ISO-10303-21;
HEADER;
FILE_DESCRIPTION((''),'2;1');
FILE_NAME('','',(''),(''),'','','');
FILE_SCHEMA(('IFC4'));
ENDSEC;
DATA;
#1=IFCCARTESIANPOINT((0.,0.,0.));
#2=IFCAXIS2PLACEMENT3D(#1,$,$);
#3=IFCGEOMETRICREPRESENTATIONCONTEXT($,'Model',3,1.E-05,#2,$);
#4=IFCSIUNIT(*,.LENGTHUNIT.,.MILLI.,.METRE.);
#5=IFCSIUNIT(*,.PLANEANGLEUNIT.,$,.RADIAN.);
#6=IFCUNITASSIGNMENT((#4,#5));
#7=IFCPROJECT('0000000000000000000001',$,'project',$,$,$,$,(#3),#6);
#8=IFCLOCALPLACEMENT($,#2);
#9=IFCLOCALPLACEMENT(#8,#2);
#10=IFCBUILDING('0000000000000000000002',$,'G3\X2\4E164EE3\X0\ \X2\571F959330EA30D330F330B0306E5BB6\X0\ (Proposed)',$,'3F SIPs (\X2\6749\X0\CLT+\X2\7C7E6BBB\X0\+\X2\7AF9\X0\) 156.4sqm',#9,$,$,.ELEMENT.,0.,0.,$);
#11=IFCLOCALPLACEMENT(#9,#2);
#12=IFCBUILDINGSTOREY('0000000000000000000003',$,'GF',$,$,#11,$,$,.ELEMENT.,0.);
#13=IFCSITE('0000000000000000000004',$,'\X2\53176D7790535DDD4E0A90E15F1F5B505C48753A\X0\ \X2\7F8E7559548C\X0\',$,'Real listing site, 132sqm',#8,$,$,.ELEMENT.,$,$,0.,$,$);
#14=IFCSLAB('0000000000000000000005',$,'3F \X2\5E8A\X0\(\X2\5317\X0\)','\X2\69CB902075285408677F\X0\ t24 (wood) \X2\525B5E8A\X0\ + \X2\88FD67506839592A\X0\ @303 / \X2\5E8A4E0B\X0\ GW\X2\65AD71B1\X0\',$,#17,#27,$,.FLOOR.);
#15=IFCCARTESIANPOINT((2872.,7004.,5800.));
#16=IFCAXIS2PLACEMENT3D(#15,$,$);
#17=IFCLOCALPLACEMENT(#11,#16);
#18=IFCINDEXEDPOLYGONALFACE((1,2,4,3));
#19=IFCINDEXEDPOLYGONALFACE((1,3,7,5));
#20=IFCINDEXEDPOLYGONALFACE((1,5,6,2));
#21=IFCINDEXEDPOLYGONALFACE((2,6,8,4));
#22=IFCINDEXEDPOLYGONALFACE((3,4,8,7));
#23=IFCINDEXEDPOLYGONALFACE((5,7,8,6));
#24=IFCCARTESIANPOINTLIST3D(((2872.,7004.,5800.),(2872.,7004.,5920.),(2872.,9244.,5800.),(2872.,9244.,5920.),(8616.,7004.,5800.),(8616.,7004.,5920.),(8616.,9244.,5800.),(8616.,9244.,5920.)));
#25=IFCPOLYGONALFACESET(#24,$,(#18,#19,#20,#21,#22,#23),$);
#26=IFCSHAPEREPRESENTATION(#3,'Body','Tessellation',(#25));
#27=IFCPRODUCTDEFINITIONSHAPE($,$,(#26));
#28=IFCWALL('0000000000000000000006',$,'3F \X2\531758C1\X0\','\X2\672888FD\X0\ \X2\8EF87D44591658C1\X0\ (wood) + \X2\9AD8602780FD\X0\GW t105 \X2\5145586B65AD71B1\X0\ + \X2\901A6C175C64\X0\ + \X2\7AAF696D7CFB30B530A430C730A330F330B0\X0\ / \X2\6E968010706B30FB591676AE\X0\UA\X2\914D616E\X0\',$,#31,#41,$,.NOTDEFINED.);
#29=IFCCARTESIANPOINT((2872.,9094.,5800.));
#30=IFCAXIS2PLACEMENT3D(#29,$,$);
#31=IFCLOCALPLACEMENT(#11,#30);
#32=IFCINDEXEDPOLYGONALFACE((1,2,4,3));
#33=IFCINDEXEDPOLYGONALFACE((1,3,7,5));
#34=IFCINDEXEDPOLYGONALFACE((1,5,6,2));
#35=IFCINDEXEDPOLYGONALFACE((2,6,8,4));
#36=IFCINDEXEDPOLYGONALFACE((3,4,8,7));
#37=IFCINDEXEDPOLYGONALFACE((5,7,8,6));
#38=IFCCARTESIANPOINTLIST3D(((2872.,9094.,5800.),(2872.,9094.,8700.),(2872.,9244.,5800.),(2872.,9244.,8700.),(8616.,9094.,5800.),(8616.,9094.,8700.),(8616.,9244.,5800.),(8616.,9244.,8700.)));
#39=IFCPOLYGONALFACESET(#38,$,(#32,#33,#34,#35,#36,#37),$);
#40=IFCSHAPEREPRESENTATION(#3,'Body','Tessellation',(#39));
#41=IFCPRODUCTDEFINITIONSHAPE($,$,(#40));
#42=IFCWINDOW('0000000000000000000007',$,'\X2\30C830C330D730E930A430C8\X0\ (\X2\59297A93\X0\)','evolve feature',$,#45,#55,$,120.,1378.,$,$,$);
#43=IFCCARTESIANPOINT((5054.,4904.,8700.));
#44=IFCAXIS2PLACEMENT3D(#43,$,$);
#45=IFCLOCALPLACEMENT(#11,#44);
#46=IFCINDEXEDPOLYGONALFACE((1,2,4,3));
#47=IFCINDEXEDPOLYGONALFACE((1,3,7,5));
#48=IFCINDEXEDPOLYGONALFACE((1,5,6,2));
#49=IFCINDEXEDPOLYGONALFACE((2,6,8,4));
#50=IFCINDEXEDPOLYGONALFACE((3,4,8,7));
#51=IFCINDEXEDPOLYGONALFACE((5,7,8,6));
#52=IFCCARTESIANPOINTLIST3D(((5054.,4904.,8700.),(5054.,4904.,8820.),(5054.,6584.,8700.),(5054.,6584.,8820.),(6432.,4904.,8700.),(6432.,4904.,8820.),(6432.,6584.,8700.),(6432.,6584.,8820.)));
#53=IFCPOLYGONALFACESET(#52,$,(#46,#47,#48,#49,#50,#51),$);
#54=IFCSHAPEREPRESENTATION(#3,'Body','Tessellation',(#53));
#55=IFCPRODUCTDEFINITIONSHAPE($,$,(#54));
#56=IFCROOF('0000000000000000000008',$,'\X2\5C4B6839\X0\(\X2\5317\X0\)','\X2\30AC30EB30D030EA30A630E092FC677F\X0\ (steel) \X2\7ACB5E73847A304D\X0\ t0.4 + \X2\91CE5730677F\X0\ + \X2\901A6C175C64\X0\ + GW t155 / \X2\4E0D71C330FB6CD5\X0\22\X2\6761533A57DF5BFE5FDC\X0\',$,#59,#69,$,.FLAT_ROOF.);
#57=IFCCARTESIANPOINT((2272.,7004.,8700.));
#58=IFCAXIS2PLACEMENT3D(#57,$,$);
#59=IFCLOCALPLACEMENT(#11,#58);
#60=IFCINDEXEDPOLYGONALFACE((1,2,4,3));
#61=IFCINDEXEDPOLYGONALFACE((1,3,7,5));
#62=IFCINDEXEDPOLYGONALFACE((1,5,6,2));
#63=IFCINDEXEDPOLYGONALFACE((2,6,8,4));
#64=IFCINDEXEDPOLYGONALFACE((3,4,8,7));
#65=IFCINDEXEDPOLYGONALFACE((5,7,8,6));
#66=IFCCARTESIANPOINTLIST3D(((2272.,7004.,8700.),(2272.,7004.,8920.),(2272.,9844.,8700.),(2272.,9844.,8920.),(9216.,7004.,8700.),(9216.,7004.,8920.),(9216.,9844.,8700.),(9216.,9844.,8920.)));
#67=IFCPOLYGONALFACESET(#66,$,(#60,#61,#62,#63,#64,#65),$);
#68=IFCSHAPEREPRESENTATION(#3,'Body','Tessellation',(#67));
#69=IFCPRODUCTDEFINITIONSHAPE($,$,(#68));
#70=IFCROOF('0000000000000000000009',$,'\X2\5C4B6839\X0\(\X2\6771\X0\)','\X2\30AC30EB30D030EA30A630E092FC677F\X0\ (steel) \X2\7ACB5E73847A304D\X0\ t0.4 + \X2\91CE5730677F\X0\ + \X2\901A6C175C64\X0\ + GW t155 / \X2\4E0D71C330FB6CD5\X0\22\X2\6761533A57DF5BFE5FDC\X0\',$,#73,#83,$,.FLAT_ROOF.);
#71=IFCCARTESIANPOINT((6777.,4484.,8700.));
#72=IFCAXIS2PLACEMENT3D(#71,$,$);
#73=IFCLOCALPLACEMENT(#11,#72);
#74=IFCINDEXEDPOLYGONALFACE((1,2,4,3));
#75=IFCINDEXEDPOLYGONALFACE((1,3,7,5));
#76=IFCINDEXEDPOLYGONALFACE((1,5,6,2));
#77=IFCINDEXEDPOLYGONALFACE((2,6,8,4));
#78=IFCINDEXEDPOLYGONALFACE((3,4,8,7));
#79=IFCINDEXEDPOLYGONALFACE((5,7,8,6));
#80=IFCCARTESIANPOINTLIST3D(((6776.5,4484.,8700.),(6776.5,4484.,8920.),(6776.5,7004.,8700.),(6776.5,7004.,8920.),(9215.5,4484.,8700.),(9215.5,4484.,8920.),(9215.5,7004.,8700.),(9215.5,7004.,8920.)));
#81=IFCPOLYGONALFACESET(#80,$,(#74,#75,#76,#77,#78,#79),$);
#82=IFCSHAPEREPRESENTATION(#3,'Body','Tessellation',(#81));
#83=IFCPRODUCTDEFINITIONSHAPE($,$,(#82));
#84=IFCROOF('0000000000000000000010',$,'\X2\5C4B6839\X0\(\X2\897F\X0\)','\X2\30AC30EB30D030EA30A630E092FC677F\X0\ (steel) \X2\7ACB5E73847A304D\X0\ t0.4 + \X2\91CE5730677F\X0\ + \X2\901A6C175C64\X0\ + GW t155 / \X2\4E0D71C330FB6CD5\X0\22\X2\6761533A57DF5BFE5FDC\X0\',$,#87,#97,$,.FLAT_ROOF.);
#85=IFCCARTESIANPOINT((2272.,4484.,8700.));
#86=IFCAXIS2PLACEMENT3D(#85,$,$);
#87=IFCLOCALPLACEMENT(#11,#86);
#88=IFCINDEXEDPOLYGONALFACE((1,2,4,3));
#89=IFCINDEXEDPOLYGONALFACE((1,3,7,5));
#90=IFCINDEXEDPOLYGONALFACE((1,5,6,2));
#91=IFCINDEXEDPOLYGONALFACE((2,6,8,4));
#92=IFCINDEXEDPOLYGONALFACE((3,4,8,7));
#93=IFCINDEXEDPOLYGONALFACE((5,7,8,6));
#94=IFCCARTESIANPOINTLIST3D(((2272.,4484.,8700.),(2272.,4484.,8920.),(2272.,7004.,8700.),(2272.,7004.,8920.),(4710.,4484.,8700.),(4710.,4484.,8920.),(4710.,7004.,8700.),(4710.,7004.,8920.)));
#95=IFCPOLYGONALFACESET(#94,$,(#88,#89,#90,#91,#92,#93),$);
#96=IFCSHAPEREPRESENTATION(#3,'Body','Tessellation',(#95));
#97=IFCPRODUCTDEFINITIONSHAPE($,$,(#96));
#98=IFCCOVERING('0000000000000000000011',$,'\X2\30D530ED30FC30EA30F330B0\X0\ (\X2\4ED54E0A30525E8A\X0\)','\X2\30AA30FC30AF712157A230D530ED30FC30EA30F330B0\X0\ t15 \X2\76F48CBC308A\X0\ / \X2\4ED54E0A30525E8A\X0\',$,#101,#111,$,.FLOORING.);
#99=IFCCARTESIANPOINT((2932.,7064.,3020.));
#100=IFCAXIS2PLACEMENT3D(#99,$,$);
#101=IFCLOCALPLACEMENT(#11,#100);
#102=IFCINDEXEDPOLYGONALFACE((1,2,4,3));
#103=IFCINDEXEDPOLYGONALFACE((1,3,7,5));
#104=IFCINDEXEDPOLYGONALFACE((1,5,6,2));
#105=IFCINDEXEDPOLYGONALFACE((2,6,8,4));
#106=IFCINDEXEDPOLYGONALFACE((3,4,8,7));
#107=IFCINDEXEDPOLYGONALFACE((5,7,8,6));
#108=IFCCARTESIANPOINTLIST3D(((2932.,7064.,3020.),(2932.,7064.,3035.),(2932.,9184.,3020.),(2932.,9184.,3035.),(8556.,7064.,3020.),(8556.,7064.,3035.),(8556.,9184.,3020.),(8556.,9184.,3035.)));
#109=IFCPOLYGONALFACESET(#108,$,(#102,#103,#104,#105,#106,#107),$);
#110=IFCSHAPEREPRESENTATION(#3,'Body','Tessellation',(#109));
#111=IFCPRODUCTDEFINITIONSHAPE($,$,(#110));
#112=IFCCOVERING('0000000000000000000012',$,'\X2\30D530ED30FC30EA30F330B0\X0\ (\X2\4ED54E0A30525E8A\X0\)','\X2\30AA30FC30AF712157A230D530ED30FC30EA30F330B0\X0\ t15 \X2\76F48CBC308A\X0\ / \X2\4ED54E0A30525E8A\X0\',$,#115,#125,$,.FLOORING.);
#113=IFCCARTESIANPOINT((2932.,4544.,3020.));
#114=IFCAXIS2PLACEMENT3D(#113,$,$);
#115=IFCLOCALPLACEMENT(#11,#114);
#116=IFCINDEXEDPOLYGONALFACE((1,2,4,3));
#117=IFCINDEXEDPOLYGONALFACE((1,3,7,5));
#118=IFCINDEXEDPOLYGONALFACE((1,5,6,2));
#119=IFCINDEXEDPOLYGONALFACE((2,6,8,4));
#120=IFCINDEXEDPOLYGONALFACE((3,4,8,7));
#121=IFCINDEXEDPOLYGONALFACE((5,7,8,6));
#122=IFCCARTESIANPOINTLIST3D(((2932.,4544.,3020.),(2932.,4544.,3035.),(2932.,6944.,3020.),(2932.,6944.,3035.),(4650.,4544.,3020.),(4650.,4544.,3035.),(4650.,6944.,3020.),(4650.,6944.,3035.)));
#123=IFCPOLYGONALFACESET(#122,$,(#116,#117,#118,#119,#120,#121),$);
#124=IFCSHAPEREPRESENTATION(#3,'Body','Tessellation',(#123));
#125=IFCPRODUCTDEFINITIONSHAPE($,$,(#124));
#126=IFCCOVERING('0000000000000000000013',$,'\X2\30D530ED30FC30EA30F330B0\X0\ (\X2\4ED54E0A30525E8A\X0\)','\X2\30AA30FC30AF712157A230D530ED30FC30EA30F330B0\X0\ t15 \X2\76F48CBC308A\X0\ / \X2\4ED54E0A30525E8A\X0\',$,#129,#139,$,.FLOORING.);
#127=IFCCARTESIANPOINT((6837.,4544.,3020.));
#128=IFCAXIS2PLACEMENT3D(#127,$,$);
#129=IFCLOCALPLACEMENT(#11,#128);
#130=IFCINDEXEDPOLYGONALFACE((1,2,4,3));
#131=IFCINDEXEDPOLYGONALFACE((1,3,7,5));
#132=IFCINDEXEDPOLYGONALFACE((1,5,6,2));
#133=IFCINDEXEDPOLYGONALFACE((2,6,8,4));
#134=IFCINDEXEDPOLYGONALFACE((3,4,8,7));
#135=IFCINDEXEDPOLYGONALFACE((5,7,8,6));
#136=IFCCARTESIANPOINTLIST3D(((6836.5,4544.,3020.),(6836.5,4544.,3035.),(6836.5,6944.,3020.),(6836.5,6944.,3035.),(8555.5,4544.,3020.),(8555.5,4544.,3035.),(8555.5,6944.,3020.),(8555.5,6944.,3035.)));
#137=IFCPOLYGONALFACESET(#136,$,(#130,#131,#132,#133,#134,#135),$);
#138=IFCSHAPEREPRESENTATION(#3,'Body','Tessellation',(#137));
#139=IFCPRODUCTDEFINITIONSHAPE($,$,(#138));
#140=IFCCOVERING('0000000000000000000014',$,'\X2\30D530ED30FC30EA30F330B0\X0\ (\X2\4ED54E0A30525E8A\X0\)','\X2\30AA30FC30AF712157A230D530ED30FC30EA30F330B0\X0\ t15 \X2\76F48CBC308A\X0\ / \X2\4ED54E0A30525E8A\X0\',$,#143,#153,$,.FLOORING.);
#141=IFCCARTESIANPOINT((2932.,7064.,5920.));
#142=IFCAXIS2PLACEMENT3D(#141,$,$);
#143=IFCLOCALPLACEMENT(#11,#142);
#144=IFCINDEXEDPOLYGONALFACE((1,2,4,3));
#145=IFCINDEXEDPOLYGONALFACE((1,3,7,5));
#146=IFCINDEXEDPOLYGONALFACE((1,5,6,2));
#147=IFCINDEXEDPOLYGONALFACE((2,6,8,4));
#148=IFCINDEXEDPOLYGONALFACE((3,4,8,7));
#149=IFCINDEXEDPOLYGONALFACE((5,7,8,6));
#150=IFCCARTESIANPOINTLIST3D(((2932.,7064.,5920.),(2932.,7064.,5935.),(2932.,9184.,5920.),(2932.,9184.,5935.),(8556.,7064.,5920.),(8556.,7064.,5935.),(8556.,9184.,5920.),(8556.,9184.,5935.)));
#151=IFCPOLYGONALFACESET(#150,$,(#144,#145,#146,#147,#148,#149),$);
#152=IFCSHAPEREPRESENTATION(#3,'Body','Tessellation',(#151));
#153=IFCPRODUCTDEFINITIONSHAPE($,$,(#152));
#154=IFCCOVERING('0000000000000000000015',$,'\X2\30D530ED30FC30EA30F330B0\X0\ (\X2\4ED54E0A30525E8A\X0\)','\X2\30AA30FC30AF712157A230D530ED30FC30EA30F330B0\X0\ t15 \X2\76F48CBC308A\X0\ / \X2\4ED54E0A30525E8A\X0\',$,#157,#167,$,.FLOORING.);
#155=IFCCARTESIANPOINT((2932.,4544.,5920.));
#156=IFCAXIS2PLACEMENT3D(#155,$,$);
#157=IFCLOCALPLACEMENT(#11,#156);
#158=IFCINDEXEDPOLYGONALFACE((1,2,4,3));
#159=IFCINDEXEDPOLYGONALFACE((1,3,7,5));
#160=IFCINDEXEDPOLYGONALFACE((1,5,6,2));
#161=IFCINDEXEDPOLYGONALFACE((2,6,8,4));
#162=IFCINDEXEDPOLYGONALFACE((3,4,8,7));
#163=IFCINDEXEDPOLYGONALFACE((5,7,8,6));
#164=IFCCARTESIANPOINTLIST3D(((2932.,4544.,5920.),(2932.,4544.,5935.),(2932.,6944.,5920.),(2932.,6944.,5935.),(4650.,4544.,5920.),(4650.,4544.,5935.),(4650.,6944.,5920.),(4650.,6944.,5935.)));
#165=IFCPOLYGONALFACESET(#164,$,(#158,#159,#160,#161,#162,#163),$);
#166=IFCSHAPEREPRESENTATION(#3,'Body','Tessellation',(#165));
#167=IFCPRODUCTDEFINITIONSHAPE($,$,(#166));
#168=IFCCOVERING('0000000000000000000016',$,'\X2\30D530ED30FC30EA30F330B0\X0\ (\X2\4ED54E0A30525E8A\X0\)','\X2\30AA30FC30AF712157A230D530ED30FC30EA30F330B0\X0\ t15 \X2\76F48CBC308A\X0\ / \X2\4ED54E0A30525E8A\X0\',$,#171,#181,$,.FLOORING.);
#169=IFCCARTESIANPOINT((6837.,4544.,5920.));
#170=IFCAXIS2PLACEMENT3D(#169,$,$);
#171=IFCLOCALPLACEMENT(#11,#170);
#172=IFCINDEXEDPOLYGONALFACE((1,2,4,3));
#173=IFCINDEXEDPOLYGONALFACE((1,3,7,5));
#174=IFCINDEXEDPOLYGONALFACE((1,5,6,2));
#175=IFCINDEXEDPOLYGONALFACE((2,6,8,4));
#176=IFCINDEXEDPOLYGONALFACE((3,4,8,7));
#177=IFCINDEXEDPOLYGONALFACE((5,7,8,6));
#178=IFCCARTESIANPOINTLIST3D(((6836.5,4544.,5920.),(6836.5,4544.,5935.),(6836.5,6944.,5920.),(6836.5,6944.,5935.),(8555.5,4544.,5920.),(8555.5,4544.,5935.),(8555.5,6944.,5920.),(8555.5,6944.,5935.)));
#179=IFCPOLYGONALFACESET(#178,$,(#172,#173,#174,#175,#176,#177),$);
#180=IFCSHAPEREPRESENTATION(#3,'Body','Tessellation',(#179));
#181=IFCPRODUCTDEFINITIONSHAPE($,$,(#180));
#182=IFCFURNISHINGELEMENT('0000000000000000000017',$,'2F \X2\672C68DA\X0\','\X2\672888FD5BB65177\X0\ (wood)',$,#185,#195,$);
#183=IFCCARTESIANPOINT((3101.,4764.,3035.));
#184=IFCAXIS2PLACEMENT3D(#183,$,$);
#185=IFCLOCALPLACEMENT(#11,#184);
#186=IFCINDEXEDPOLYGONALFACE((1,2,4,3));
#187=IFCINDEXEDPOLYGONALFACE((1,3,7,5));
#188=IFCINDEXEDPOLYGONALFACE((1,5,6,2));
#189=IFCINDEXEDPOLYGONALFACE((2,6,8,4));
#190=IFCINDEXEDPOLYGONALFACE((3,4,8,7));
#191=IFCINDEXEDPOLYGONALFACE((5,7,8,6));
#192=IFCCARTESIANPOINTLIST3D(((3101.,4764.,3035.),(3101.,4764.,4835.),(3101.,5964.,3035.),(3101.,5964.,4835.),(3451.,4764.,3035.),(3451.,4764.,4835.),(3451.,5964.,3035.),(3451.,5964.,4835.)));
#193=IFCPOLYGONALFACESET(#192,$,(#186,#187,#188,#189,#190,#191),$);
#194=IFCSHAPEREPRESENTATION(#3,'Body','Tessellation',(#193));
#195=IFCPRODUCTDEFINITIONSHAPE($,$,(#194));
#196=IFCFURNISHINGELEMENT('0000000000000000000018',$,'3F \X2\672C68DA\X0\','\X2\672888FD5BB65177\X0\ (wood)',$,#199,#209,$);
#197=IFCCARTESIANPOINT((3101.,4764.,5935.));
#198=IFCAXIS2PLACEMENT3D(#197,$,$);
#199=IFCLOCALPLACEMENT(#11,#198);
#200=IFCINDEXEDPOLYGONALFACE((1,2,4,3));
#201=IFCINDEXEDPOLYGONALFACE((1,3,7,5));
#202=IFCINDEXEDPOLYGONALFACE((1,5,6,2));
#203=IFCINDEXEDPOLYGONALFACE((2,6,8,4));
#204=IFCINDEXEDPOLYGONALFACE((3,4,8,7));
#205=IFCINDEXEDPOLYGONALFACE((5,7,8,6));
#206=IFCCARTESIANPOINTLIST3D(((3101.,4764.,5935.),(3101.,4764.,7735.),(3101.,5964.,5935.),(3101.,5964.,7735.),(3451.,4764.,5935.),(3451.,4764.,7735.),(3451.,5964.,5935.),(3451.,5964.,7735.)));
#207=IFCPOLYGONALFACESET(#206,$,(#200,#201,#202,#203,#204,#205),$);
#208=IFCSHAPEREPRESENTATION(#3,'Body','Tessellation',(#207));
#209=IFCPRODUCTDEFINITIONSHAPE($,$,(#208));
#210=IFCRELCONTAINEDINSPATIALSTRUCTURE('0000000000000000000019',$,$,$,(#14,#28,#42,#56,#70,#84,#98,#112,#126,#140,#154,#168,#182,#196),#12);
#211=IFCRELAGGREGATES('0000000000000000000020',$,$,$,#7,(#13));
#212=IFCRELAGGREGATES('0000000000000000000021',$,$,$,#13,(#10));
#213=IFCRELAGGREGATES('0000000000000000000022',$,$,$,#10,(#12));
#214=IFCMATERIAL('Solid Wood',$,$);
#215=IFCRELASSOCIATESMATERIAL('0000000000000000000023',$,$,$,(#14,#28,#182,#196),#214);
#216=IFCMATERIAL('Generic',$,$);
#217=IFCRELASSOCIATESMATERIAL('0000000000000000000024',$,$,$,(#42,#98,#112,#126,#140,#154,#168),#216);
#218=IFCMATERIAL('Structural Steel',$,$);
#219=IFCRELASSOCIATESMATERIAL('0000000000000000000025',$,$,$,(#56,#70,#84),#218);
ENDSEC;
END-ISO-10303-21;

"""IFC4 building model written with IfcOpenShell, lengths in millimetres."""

from ifc_helpers import new_model, si_unit, frame, frame_2d, origin, place, context, project, spatial, rectangle, extrude, material, element, save


model = new_model("IFC4")

# Units and contexts
model_context = context("Model", 3, precision=1e-05, world=origin())
ifc_project = project(units=[si_unit("LENGTHUNIT", "METRE", prefix="MILLI"), si_unit("PLANEANGLEUNIT", "RADIAN")], contexts=[model_context])

# Site, building, storey
site_placement = place(None, origin())
site = spatial("IfcSite", under=ifc_project, at=site_placement, Name="北海道川上郡弟子屈町 美留和", ObjectType="Real listing site, 132sqm", CompositionType="ELEMENT", RefElevation=0.0)
building_placement = place(site_placement, origin())
building = spatial("IfcBuilding", under=site, at=building_placement, Name="G3世代 土間リビングの家 (Proposed)", ObjectType="3F SIPs (杉CLT+籾殻+竹) 156.4sqm", CompositionType="ELEMENT", ElevationOfRefHeight=0.0, ElevationOfTerrain=0.0)
storey_placement = place(building_placement, origin())
storey = spatial("IfcBuildingStorey", under=building, at=storey_placement, Name="GF", CompositionType="ELEMENT", Elevation=0.0)

# Slab
ifc_material_1 = material(Name="Solid Wood")
slab_placement = place(storey_placement, frame((2872.0, 7004.0, 5800.0)))
element("IfcSlab", 1, at=slab_placement, inside=storey, material=ifc_material_1, Name="3F 床(北)", Description="構造用合板 t24 (wood) 剛床 + 製材根太 @303 / 床下 GW断熱", PredefinedType="FLOOR", context=model_context, shape_type="SweptSolid", body=[
    extrude(rectangle(XDim=5744.0, YDim=2240.0, at=frame_2d((2872.0, 1120.0))), frame((2872.0, 7004.0, 5800.0)), (0.0, 0.0, 1.0), 120.0),
])

# Wall
wall_1_placement = place(storey_placement, frame((2872.0, 9094.0, 5800.0)))
element("IfcWall", 2, at=wall_1_placement, inside=storey, material=ifc_material_1, Name="3F 北壁", Description="木製 軸組外壁 (wood) + 高性能GW t105 充填断熱 + 通気層 + 窯業系サイディング / 準耐火・外皮UA配慮", PredefinedType="NOTDEFINED", context=model_context, shape_type="SweptSolid", body=[
    extrude(rectangle(XDim=5744.0, YDim=150.0, at=frame_2d((2872.0, 75.0))), frame((2872.0, 9094.0, 5800.0)), (0.0, 0.0, 1.0), 2900.0),
])

# Window
ifc_material_2 = material(Name="Generic")
window_1_placement = place(storey_placement, frame((5054.0, 4904.0, 8700.0)))
element("IfcWindow", 3, at=window_1_placement, inside=storey, material=ifc_material_2, Name="トップライト (天窓)", Description="evolve feature", OverallHeight=120.0, OverallWidth=1378.0, context=model_context, shape_type="SweptSolid", body=[
    extrude(rectangle(XDim=1378.0, YDim=1680.0, at=frame_2d((689.0, 840.0))), frame((5054.0, 4904.0, 8700.0)), (0.0, 0.0, 1.0), 120.0),
])

# Roofs
ifc_material_3 = material(Name="Structural Steel")
roof_1_placement = place(storey_placement, frame((2272.0, 7004.0, 8700.0)))
element("IfcRoof", 4, at=roof_1_placement, inside=storey, material=ifc_material_3, Name="屋根(北)", Description="ガルバリウム鋼板 (steel) 立平葺き t0.4 + 野地板 + 通気層 + GW t155 / 不燃・法22条区域対応", PredefinedType="FLAT_ROOF", context=model_context, shape_type="SweptSolid", body=[
    extrude(rectangle(XDim=6944.0, YDim=2840.0, at=frame_2d((3472.0, 1420.0))), frame((2272.0, 7004.0, 8700.0)), (0.0, 0.0, 1.0), 220.0),
])
roof_2_placement = place(storey_placement, frame((6777.0, 4484.0, 8700.0)))
element("IfcRoof", 5, at=roof_2_placement, inside=storey, material=ifc_material_3, Name="屋根(東)", Description="ガルバリウム鋼板 (steel) 立平葺き t0.4 + 野地板 + 通気層 + GW t155 / 不燃・法22条区域対応", PredefinedType="FLAT_ROOF", context=model_context, shape_type="SweptSolid", body=[
    extrude(rectangle(XDim=2439.0, YDim=2520.0, at=frame_2d((1219.0, 1260.0))), frame((6777.0, 4484.0, 8700.0)), (0.0, 0.0, 1.0), 220.0),
])
roof_3_placement = place(storey_placement, frame((2272.0, 4484.0, 8700.0)))
element("IfcRoof", 6, at=roof_3_placement, inside=storey, material=ifc_material_3, Name="屋根(西)", Description="ガルバリウム鋼板 (steel) 立平葺き t0.4 + 野地板 + 通気層 + GW t155 / 不燃・法22条区域対応", PredefinedType="FLAT_ROOF", context=model_context, shape_type="SweptSolid", body=[
    extrude(rectangle(XDim=2438.0, YDim=2520.0, at=frame_2d((1219.0, 1260.0))), frame((2272.0, 4484.0, 8700.0)), (0.0, 0.0, 1.0), 220.0),
])

# Coverings
covering_1_placement = place(storey_placement, frame((2932.0, 7064.0, 3020.0)))
element("IfcCovering", 7, at=covering_1_placement, inside=storey, material=ifc_material_2, Name="フローリング (仕上げ床)", Description="オーク無垢フローリング t15 直貼り / 仕上げ床", PredefinedType="FLOORING", context=model_context, shape_type="SweptSolid", body=[
    extrude(rectangle(XDim=5624.0, YDim=2120.0, at=frame_2d((2812.0, 1060.0))), frame((2932.0, 7064.0, 3020.0)), (0.0, 0.0, 1.0), 15.0),
])
covering_2_placement = place(storey_placement, frame((2932.0, 4544.0, 3020.0)))
element("IfcCovering", 8, at=covering_2_placement, inside=storey, material=ifc_material_2, Name="フローリング (仕上げ床)", Description="オーク無垢フローリング t15 直貼り / 仕上げ床", PredefinedType="FLOORING", context=model_context, shape_type="SweptSolid", body=[
    extrude(rectangle(XDim=1718.0, YDim=2400.0, at=frame_2d((859.0, 1200.0))), frame((2932.0, 4544.0, 3020.0)), (0.0, 0.0, 1.0), 15.0),
])
covering_3_placement = place(storey_placement, frame((6837.0, 4544.0, 3020.0)))
element("IfcCovering", 9, at=covering_3_placement, inside=storey, material=ifc_material_2, Name="フローリング (仕上げ床)", Description="オーク無垢フローリング t15 直貼り / 仕上げ床", PredefinedType="FLOORING", context=model_context, shape_type="SweptSolid", body=[
    extrude(rectangle(XDim=1719.0, YDim=2400.0, at=frame_2d((859.0, 1200.0))), frame((6837.0, 4544.0, 3020.0)), (0.0, 0.0, 1.0), 15.0),
])
covering_4_placement = place(storey_placement, frame((2932.0, 7064.0, 5920.0)))
element("IfcCovering", 10, at=covering_4_placement, inside=storey, material=ifc_material_2, Name="フローリング (仕上げ床)", Description="オーク無垢フローリング t15 直貼り / 仕上げ床", PredefinedType="FLOORING", context=model_context, shape_type="SweptSolid", body=[
    extrude(rectangle(XDim=5624.0, YDim=2120.0, at=frame_2d((2812.0, 1060.0))), frame((2932.0, 7064.0, 5920.0)), (0.0, 0.0, 1.0), 15.0),
])
covering_5_placement = place(storey_placement, frame((2932.0, 4544.0, 5920.0)))
element("IfcCovering", 11, at=covering_5_placement, inside=storey, material=ifc_material_2, Name="フローリング (仕上げ床)", Description="オーク無垢フローリング t15 直貼り / 仕上げ床", PredefinedType="FLOORING", context=model_context, shape_type="SweptSolid", body=[
    extrude(rectangle(XDim=1718.0, YDim=2400.0, at=frame_2d((859.0, 1200.0))), frame((2932.0, 4544.0, 5920.0)), (0.0, 0.0, 1.0), 15.0),
])
covering_6_placement = place(storey_placement, frame((6837.0, 4544.0, 5920.0)))
element("IfcCovering", 12, at=covering_6_placement, inside=storey, material=ifc_material_2, Name="フローリング (仕上げ床)", Description="オーク無垢フローリング t15 直貼り / 仕上げ床", PredefinedType="FLOORING", context=model_context, shape_type="SweptSolid", body=[
    extrude(rectangle(XDim=1719.0, YDim=2400.0, at=frame_2d((859.0, 1200.0))), frame((6837.0, 4544.0, 5920.0)), (0.0, 0.0, 1.0), 15.0),
])

# Furnishing elements
furnishing_1_placement = place(storey_placement, frame((3101.0, 4764.0, 3035.0)))
element("IfcFurnishingElement", 13, at=furnishing_1_placement, inside=storey, material=ifc_material_1, Name="2F 本棚", Description="木製家具 (wood)", context=model_context, shape_type="SweptSolid", body=[
    extrude(rectangle(XDim=350.0, YDim=1200.0, at=frame_2d((175.0, 600.0))), frame((3101.0, 4764.0, 3035.0)), (0.0, 0.0, 1.0), 1800.0),
])
furnishing_2_placement = place(storey_placement, frame((3101.0, 4764.0, 5935.0)))
element("IfcFurnishingElement", 14, at=furnishing_2_placement, inside=storey, material=ifc_material_1, Name="3F 本棚", Description="木製家具 (wood)", context=model_context, shape_type="SweptSolid", body=[
    extrude(rectangle(XDim=350.0, YDim=1200.0, at=frame_2d((175.0, 600.0))), frame((3101.0, 4764.0, 5935.0)), (0.0, 0.0, 1.0), 1800.0),
])

save(model, "model.ifc")
